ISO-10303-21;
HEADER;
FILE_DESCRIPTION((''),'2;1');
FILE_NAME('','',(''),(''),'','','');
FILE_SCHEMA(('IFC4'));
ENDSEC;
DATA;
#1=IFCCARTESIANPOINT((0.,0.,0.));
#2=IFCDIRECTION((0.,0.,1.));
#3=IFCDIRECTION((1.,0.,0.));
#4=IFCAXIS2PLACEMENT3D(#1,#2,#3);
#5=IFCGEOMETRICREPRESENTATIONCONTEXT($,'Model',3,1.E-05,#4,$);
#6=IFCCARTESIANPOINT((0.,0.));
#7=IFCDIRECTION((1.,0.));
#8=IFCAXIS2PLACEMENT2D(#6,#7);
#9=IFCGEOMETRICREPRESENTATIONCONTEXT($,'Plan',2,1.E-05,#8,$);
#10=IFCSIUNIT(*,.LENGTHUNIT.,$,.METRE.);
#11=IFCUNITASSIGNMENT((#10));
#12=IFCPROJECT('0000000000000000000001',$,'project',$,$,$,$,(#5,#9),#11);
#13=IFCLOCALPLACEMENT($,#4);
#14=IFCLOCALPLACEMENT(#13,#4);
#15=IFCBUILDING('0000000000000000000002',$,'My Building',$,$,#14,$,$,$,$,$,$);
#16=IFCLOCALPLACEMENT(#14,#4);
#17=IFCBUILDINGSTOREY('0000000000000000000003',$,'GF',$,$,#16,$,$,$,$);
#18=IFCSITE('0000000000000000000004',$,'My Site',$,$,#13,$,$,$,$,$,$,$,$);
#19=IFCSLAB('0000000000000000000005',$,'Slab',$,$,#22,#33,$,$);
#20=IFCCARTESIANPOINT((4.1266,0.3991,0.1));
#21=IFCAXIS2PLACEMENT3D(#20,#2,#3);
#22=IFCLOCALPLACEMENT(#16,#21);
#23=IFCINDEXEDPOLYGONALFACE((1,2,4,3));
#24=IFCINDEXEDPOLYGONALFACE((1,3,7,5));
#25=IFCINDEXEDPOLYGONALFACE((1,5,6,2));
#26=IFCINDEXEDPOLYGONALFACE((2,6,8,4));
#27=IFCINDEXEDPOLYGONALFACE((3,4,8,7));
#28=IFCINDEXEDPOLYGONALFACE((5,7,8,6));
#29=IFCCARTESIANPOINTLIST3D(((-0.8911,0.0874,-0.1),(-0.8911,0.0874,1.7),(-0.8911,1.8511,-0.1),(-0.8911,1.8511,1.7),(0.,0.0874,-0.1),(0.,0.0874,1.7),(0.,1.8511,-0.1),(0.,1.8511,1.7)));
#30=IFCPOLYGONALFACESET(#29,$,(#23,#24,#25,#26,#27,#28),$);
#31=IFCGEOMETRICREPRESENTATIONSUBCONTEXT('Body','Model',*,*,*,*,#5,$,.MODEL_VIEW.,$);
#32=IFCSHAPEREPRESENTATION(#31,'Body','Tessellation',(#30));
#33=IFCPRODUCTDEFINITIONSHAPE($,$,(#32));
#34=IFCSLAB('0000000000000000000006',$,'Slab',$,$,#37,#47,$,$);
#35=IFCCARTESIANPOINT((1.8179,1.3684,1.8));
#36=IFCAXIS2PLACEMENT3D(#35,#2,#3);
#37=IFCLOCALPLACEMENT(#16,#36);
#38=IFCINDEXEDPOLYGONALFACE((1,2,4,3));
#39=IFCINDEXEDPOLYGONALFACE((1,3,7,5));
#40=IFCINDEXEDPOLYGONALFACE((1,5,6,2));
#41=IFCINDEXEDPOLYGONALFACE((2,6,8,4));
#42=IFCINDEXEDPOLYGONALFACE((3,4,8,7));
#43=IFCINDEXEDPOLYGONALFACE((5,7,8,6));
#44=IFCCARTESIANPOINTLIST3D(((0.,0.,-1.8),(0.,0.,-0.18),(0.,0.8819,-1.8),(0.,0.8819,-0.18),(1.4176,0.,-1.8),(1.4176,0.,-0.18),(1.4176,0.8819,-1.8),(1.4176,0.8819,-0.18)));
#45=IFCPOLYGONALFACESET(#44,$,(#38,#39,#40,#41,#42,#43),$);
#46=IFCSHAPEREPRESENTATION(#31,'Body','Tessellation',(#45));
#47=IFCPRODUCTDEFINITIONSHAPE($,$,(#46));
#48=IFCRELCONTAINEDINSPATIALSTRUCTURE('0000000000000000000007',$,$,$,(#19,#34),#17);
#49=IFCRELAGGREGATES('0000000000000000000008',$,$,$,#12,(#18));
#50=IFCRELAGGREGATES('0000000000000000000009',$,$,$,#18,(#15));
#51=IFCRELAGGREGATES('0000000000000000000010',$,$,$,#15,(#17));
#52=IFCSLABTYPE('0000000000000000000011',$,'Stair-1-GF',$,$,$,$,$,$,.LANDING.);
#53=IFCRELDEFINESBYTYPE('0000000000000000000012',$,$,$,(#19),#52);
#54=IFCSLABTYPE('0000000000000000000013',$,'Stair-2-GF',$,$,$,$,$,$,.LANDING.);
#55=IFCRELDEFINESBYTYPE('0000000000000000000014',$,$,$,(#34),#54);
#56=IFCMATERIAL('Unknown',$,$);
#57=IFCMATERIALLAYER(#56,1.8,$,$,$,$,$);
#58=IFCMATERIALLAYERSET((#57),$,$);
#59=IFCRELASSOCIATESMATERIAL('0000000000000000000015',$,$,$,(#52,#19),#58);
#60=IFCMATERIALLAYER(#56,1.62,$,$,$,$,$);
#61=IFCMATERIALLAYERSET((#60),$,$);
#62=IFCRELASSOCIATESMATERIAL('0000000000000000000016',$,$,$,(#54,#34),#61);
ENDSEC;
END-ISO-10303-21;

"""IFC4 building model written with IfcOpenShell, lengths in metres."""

from ifc_helpers import new_model, si_unit, frame, origin_with_axes, origin_2d_with_axis, place, context, subcontext, project, spatial, indexed_curve, outline, extrude, material, layer, layer_set, layer_usage, type_object, element, save


model = new_model("IFC4")

# Units and contexts
model_context = context("Model", 3, precision=1e-05, world=origin_with_axes())
plan_context = context("Plan", 2, precision=1e-05, world=origin_2d_with_axis())
body_context_1 = subcontext(model_context, "Body", "Model", "MODEL_VIEW")
ifc_project = project(units=[si_unit("LENGTHUNIT", "METRE")], contexts=[model_context, plan_context])

# Site, building, storey
site_placement = place(None, origin_with_axes())
site = spatial("IfcSite", under=ifc_project, at=site_placement, Name="My Site")
building_placement = place(site_placement, origin_with_axes())
building = spatial("IfcBuilding", under=site, at=building_placement, Name="My Building")
storey_placement = place(building_placement, origin_with_axes())
storey = spatial("IfcBuildingStorey", under=building, at=storey_placement, Name="GF")

# Slabs
ifc_material_1 = material(Name="Unknown")
ifc_layer_1 = layer(ifc_material_1, 1.8)
ifc_layer_set_1 = layer_set([ifc_layer_1])
ifc_layer_usage_1 = layer_usage(ifc_layer_set_1, "AXIS3", "POSITIVE", -0.1)
slab_type_1 = type_object("IfcSlabType", Name="Stair-1-GF", PredefinedType="LANDING", material=ifc_layer_set_1)
slab_1_placement = place(storey_placement, frame((4.1266, 0.3991, 0.1), z_axis=(0.0, 0.0, 1.0), x_axis=(1.0, 0.0, 0.0)))
element("IfcSlab", 1, at=slab_1_placement, inside=storey, type_object=slab_type_1, material=ifc_layer_usage_1, Name="Slab", context=body_context_1, shape_type="SweptSolid", body=[
    extrude(outline(indexed_curve([(0.0, 0.0874), (0.0, 1.8511), (-0.8911, 1.8511), (-0.8911, 0.0874), (0.0, 0.0874)])), frame((0.0, 0.0, -0.1), z_axis=(0.0, 0.0, 1.0), x_axis=(1.0, 0.0, 0.0)), (0.0, 0.0, 1.0), 1.8),
])
ifc_layer_2 = layer(ifc_material_1, 1.62)
ifc_layer_set_2 = layer_set([ifc_layer_2])
ifc_layer_usage_2 = layer_usage(ifc_layer_set_2, "AXIS3", "POSITIVE", -1.8)
slab_type_2 = type_object("IfcSlabType", Name="Stair-2-GF", PredefinedType="LANDING", material=ifc_layer_set_2)
slab_2_placement = place(storey_placement, frame((1.8179, 1.3684, 1.8), z_axis=(0.0, 0.0, 1.0), x_axis=(1.0, 0.0, 0.0)))
element("IfcSlab", 2, at=slab_2_placement, inside=storey, type_object=slab_type_2, material=ifc_layer_usage_2, Name="Slab", context=body_context_1, shape_type="SweptSolid", body=[
    extrude(outline(indexed_curve([(0.0, 0.8819), (1.4176, 0.8819), (1.4176, 0.0), (0.0, 0.0), (0.0, 0.8819)])), frame((0.0, 0.0, -1.8), z_axis=(0.0, 0.0, 1.0), x_axis=(1.0, 0.0, 0.0)), (0.0, 0.0, 1.0), 1.62),
])

save(model, "model.ifc")
